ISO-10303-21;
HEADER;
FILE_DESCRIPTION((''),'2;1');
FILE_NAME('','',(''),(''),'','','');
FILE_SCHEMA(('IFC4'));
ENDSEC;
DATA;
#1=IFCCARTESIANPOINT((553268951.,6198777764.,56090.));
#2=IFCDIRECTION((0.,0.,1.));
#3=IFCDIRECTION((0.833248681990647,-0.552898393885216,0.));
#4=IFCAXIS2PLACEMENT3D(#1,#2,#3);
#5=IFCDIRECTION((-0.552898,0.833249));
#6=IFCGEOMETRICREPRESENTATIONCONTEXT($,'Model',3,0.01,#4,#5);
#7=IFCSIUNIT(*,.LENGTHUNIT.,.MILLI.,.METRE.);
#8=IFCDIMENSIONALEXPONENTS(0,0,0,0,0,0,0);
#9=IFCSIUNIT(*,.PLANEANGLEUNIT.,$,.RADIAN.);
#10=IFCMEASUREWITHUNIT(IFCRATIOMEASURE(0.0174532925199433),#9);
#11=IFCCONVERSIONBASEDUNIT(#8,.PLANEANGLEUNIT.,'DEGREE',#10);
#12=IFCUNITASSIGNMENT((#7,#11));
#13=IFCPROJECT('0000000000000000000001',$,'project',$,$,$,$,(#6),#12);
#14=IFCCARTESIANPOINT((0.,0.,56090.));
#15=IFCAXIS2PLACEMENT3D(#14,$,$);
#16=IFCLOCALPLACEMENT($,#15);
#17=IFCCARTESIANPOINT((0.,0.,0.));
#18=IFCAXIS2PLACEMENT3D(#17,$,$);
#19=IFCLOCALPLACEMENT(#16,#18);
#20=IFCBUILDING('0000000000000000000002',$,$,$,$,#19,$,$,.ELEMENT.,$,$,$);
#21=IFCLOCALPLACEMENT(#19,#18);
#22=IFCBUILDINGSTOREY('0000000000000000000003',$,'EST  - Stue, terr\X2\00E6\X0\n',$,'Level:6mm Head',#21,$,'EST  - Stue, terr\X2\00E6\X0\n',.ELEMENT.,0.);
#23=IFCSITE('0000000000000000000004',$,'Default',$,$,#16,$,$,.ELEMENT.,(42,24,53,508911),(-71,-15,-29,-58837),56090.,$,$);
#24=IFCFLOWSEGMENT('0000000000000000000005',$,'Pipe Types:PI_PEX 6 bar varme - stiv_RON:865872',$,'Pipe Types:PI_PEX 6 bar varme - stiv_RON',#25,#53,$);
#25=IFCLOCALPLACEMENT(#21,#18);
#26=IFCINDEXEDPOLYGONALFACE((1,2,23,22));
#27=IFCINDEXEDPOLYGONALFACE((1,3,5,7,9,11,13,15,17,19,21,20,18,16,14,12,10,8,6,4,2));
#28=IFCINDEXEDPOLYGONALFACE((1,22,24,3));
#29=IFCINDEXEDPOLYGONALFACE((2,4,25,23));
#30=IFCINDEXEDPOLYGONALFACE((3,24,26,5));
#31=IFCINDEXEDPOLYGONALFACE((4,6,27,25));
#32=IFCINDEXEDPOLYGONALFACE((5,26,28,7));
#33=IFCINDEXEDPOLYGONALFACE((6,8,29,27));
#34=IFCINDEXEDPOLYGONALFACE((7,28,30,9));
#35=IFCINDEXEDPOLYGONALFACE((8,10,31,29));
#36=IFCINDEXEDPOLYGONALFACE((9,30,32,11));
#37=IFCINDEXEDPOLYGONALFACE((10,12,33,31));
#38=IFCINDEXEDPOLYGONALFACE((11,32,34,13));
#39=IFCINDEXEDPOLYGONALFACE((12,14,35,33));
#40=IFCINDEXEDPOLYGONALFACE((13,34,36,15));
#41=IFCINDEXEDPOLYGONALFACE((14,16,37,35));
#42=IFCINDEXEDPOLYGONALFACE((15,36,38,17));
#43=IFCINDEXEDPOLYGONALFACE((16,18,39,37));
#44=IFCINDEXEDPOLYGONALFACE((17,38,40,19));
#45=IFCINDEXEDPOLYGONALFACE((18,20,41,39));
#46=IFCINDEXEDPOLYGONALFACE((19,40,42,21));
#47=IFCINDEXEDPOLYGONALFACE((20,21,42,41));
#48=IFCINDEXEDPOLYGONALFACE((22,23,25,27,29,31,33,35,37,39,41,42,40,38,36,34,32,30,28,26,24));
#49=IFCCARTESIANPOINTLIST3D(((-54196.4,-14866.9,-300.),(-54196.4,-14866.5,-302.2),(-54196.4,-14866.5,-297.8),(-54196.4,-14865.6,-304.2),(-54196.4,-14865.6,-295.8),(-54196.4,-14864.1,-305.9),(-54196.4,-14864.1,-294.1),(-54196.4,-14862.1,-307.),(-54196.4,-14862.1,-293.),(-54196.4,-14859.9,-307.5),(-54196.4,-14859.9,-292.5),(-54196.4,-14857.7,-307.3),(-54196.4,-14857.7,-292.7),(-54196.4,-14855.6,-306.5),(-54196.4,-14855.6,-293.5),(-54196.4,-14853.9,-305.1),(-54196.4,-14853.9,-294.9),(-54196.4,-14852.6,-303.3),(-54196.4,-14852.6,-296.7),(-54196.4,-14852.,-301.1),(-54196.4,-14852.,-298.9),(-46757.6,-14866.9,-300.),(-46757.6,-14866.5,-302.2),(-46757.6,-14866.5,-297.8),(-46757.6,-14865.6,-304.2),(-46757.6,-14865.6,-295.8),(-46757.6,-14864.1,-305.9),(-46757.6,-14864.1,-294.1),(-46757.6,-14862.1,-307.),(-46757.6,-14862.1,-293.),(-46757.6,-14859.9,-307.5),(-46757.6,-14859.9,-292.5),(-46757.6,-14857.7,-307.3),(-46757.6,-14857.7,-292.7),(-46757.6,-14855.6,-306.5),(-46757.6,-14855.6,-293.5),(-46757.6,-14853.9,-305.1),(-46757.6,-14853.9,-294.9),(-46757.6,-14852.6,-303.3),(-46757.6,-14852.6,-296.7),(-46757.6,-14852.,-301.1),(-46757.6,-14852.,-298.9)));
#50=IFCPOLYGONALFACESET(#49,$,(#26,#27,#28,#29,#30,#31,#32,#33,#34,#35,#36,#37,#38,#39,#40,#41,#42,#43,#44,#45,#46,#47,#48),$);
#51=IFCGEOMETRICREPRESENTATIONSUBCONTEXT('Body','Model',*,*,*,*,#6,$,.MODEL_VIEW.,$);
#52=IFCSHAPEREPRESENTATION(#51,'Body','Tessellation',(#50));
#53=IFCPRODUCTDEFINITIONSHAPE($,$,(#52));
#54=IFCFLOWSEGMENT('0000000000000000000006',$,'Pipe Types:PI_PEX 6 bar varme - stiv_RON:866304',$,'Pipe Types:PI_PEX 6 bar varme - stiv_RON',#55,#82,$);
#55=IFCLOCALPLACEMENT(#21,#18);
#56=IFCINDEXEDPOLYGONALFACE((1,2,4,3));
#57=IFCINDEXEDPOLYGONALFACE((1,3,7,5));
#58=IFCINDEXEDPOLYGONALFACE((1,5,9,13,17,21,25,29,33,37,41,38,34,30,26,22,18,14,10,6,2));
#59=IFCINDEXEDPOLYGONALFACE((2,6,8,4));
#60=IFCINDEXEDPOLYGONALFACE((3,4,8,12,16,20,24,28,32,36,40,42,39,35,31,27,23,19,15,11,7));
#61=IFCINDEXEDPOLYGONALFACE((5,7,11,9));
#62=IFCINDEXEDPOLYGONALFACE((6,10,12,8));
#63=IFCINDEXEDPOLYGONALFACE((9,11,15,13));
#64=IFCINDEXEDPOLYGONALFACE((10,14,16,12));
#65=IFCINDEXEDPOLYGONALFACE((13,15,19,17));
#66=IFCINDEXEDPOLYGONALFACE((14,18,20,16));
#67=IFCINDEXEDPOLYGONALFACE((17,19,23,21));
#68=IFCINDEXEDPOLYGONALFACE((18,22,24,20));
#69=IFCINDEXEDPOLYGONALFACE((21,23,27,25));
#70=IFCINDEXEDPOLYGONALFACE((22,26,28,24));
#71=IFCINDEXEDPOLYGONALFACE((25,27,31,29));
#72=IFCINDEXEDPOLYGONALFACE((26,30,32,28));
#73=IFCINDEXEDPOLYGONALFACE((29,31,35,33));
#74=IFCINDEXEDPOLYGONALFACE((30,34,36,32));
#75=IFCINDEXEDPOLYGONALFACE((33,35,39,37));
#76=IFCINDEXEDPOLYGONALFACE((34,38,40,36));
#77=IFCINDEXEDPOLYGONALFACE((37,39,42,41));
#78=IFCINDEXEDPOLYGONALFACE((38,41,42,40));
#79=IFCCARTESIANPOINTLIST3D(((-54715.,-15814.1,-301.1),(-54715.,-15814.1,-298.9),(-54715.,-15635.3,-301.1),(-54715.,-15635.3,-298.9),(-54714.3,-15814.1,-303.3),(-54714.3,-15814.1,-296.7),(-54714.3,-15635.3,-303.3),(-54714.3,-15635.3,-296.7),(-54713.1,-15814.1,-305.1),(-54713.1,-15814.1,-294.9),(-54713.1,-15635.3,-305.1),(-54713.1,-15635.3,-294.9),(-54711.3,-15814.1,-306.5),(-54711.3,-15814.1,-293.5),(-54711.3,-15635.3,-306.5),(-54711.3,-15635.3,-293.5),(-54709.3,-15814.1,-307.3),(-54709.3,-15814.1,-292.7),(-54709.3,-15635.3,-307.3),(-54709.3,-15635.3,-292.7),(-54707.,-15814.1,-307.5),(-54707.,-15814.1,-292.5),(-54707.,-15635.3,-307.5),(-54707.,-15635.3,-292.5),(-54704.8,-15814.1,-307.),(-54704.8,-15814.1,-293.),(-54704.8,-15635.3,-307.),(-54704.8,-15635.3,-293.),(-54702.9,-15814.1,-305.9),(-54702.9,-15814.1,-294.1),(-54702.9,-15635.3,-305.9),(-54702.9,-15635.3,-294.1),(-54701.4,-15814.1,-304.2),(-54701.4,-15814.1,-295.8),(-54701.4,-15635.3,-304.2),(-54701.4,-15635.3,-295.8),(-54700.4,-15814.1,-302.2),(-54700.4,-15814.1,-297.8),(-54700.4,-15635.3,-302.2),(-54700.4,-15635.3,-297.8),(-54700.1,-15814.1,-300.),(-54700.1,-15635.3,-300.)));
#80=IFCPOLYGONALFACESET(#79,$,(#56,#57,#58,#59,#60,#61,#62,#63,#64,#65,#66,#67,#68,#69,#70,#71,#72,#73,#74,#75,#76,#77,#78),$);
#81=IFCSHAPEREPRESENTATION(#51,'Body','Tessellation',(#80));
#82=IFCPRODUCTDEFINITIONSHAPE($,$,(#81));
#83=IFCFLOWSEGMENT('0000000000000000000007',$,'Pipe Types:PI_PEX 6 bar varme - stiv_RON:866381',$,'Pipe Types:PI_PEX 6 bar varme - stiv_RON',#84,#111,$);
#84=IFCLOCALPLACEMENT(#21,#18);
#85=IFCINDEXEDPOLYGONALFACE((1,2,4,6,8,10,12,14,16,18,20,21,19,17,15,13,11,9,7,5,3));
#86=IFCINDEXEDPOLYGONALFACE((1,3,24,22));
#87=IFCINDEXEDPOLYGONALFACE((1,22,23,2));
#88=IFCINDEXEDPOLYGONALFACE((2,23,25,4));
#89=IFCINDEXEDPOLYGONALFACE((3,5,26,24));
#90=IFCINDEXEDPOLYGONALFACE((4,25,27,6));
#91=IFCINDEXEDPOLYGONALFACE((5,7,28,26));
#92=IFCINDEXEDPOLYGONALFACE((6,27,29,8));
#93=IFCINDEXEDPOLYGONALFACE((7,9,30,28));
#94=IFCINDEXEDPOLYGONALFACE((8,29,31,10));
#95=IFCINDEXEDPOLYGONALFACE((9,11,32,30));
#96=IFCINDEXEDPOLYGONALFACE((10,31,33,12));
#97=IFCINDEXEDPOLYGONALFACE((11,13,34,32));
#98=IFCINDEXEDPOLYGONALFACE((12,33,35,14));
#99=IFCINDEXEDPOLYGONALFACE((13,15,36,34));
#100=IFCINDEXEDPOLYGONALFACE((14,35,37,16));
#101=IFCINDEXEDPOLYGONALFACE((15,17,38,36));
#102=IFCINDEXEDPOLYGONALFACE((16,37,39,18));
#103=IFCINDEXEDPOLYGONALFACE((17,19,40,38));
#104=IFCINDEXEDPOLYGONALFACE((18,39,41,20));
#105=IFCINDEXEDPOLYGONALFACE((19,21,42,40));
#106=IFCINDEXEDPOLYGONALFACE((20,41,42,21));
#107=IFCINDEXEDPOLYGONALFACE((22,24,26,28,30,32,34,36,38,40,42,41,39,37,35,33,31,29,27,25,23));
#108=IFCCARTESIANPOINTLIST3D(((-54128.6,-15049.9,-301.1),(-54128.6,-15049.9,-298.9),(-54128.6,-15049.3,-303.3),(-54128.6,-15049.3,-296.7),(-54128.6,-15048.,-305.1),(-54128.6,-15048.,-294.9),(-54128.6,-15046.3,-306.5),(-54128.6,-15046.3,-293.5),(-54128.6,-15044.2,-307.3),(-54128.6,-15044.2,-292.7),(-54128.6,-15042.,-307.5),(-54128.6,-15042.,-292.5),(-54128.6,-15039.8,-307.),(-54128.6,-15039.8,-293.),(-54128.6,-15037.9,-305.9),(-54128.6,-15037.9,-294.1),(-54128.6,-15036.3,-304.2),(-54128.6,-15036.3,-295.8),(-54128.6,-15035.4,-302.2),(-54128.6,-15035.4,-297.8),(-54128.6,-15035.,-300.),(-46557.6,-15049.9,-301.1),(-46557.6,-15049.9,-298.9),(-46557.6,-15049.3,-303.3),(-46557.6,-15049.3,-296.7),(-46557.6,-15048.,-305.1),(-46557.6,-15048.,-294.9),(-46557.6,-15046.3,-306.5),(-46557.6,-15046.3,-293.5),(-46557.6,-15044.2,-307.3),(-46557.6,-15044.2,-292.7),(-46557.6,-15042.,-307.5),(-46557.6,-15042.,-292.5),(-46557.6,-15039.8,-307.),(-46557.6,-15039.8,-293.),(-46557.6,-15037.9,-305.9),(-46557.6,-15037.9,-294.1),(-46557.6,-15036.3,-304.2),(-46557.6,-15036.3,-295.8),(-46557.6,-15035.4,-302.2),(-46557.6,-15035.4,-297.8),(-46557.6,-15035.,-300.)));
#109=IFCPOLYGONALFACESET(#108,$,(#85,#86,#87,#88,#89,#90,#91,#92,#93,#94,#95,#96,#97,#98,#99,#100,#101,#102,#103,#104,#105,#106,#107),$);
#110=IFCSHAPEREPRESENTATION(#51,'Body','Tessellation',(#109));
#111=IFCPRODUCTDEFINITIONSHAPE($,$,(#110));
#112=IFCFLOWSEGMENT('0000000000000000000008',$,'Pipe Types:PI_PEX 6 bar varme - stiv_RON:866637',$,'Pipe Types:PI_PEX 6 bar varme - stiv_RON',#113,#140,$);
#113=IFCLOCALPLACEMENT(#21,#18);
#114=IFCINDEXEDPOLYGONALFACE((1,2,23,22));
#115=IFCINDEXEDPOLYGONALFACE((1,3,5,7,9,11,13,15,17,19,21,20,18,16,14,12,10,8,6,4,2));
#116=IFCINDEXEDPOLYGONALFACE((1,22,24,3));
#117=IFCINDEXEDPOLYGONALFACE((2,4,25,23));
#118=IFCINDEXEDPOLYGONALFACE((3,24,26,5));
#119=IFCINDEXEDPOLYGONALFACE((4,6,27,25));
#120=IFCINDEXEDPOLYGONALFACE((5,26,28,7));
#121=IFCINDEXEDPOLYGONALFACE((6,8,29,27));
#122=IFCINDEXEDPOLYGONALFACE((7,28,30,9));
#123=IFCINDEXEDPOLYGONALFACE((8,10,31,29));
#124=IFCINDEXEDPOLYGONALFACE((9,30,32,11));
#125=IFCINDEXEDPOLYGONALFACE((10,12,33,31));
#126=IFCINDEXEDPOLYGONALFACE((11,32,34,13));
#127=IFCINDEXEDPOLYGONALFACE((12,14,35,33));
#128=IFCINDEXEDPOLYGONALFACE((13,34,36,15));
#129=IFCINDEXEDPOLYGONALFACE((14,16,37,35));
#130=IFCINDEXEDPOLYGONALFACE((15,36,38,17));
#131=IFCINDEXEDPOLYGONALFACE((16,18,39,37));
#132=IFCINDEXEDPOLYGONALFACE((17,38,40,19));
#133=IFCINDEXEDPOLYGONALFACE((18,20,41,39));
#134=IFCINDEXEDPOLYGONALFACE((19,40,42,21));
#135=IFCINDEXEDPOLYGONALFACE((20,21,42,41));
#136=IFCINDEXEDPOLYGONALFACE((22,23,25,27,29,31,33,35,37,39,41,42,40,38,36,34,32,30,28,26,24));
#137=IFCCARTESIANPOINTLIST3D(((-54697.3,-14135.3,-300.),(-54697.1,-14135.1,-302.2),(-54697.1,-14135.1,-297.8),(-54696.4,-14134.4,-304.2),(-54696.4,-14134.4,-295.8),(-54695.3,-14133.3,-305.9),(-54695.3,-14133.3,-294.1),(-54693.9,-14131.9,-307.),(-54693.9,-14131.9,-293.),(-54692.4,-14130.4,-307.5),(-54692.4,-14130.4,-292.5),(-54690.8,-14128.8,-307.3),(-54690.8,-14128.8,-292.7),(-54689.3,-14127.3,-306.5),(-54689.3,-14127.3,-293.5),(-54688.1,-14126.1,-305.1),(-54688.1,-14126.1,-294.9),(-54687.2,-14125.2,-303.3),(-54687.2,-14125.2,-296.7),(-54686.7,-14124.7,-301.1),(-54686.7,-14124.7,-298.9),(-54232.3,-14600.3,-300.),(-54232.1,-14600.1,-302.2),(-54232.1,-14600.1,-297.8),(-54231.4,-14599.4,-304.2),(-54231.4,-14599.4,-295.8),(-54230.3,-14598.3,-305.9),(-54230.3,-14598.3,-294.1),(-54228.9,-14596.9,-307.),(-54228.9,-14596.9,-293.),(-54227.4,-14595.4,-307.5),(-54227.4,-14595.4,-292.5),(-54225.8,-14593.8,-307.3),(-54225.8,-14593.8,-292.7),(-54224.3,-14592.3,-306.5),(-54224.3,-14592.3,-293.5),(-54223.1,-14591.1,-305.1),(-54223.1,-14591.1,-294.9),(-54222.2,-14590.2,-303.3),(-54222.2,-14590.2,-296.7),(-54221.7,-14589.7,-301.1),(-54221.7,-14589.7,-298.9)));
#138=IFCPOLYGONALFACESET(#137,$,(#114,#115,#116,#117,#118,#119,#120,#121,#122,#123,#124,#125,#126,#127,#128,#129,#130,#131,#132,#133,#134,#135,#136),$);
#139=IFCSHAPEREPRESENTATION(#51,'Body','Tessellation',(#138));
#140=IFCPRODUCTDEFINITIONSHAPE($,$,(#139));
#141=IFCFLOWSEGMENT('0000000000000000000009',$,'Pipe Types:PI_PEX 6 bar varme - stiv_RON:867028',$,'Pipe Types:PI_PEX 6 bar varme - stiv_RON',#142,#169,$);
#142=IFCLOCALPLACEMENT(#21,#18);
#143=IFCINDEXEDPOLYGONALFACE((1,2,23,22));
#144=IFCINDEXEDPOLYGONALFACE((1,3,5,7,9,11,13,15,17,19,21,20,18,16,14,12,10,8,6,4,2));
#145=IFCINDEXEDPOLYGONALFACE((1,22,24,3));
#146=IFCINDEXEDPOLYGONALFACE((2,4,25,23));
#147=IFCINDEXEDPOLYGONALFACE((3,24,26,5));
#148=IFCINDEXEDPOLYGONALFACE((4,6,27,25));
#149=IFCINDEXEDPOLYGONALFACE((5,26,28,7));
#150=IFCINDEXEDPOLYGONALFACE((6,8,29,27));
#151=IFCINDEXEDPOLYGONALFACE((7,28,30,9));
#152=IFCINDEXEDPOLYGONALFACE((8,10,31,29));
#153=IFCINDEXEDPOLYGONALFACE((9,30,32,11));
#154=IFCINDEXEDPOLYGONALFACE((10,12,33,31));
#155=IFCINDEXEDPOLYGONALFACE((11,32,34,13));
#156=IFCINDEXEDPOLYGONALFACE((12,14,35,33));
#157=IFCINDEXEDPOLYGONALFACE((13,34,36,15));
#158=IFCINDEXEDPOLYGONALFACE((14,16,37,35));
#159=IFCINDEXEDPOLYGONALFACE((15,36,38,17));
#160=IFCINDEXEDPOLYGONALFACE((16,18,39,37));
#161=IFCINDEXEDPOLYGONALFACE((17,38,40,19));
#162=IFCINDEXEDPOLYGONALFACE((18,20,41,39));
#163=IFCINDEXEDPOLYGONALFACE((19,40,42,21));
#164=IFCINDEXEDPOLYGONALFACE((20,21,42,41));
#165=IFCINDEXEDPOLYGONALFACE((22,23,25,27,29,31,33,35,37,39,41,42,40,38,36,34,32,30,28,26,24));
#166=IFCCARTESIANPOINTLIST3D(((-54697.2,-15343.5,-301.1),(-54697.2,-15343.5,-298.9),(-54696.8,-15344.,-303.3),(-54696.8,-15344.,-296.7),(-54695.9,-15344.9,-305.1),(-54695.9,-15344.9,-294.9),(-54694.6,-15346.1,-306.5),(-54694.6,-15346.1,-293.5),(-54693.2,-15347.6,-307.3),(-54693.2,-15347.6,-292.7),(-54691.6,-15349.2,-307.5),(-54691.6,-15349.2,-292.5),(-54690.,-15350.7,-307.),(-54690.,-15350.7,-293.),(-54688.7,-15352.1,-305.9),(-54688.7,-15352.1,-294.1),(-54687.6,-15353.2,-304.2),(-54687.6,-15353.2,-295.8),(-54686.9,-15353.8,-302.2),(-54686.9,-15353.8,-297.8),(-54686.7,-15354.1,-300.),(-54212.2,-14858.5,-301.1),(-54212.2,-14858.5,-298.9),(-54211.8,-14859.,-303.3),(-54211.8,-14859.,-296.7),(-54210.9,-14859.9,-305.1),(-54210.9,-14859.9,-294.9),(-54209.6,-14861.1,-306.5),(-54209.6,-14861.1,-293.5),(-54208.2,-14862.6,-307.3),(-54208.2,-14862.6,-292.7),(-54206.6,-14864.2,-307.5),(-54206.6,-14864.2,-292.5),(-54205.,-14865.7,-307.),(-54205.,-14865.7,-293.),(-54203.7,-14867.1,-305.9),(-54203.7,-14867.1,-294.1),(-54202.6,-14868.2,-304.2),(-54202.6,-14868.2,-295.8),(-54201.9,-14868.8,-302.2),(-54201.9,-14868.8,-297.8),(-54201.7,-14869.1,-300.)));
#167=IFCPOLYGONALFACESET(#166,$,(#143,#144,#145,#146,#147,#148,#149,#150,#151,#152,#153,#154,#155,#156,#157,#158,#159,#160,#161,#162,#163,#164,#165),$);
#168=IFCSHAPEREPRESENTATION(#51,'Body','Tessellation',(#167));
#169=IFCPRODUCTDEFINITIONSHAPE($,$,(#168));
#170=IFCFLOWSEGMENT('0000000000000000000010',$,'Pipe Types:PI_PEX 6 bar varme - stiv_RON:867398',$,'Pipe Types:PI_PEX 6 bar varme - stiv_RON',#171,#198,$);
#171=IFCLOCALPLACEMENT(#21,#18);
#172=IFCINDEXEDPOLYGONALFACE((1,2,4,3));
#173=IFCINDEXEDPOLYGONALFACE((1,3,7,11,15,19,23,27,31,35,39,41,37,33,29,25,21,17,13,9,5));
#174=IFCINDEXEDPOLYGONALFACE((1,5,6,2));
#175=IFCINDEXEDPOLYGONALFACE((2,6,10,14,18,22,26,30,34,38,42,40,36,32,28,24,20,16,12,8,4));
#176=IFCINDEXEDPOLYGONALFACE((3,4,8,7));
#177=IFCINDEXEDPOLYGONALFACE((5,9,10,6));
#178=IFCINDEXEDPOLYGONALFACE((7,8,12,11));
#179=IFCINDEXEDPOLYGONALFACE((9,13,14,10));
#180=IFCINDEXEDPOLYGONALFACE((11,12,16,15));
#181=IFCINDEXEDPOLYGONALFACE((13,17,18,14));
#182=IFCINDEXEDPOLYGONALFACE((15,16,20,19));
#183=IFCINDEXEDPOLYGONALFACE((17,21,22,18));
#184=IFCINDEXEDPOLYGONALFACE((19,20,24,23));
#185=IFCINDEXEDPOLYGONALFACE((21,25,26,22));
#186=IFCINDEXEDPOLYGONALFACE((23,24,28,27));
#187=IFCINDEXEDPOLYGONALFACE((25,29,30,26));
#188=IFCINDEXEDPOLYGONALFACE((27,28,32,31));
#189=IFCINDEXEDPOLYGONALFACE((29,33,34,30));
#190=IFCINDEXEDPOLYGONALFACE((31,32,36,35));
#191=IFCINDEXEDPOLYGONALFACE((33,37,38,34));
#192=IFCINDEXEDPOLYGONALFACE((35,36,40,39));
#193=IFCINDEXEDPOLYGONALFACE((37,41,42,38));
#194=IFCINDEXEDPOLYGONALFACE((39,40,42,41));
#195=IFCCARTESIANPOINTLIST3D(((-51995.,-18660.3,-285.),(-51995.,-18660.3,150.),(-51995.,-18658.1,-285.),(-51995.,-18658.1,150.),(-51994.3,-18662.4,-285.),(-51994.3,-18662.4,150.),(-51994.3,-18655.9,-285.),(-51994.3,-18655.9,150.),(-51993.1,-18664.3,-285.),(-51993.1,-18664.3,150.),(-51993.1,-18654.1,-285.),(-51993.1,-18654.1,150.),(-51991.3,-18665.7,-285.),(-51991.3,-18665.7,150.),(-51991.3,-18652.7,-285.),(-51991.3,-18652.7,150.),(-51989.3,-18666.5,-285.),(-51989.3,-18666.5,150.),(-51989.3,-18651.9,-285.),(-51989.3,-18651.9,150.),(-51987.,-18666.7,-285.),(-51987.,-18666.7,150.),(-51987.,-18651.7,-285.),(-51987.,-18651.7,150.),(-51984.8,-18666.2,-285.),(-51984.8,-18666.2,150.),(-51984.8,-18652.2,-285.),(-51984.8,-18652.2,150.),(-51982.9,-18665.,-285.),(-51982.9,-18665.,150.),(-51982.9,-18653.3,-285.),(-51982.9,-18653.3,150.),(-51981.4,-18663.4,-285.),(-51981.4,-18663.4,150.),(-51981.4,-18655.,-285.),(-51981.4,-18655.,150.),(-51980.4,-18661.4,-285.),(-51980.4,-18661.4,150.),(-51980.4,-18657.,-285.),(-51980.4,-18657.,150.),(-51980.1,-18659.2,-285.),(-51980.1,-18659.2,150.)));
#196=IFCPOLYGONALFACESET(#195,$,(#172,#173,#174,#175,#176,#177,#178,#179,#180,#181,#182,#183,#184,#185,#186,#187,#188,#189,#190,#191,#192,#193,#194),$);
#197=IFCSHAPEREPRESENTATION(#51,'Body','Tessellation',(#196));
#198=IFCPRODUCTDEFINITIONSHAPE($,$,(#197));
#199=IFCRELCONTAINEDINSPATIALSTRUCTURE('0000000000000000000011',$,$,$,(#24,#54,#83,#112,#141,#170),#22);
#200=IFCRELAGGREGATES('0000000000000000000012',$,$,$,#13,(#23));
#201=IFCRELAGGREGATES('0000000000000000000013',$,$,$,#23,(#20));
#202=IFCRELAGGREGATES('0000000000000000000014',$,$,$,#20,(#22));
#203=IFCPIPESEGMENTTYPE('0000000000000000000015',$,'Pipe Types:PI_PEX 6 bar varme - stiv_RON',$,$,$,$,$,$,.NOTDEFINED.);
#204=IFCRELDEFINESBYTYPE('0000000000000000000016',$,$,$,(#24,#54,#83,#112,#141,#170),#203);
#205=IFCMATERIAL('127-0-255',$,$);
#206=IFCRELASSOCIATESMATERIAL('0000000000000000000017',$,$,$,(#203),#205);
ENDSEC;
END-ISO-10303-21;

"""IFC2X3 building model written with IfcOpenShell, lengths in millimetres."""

from ifc_helpers import new_model, entity, si_unit, converted_unit, direction, frame, frame_2d, origin, origin_2d_with_axis, place, context, subcontext, project, spatial, circle, extrude, material, type_object, element, save


model = new_model("IFC2X3")

# Units and contexts
model_context = context("Model", 3, precision=0.01, world=frame((553268951.0, 6198777764.0, 56090.0), z_axis=(0.0, 0.0, 1.0), x_axis=(0.833248681990647, -0.552898393885216, 0.0)), true_north=direction((-0.552898, 0.833249)))
body_context = subcontext(model_context, "Body", "Model", "MODEL_VIEW")
ifc_project = project(units=[si_unit("LENGTHUNIT", "METRE", prefix="MILLI"), converted_unit("PLANEANGLEUNIT", "DEGREE", entity("IfcRatioMeasure", 0.0174532925199433), si_unit("PLANEANGLEUNIT", "RADIAN"), dimensions=[0, 0, 0, 0, 0, 0, 0])], contexts=[model_context])

# Site, building, storey
site_placement = place(None, frame((0.0, 0.0, 56090.0)))
site = spatial("IfcSite", under=ifc_project, at=site_placement, Name="Default", CompositionType="ELEMENT", RefLatitude=(42, 24, 53, 508911), RefLongitude=(-71, -15, -29, -58837), RefElevation=56090.0)
building_placement = place(site_placement, origin())
building = spatial("IfcBuilding", under=site, at=building_placement, CompositionType="ELEMENT")
storey_placement = place(building_placement, frame((0.0, 0.0, 0.0)))
storey = spatial("IfcBuildingStorey", under=building, at=storey_placement, Name="EST  - Stue, terræn", ObjectType="Level:6mm Head", LongName="EST  - Stue, terræn", CompositionType="ELEMENT", Elevation=0.0)

# Flow segments
ifc_material = material(Name="127-0-255")
pipe_segment_type = type_object("IfcPipeSegmentType", Name="Pipe Types:PI_PEX 6 bar varme - stiv_RON", PredefinedType="NOTDEFINED", material=ifc_material)
flow_segment_1_placement = place(storey_placement, origin())
element("IfcFlowSegment", 1, at=flow_segment_1_placement, inside=storey, type_object=pipe_segment_type, Name="Pipe Types:PI_PEX 6 bar varme - stiv_RON:865872", ObjectType="Pipe Types:PI_PEX 6 bar varme - stiv_RON", context=body_context, shape_type="SweptSolid", body=[
    extrude(circle(Radius=7.5, at=origin_2d_with_axis()), frame((-54196.4, -14859.4, -300.0), z_axis=(1.0, 0.0, 0.0), x_axis=(0.0, -1.0, 0.0)), (0.0, 0.0, 1.0), 7438.8),
])
flow_segment_2_placement = place(storey_placement, origin())
element("IfcFlowSegment", 2, at=flow_segment_2_placement, inside=storey, type_object=pipe_segment_type, Name="Pipe Types:PI_PEX 6 bar varme - stiv_RON:866304", ObjectType="Pipe Types:PI_PEX 6 bar varme - stiv_RON", context=body_context, shape_type="SweptSolid", body=[
    extrude(circle(Radius=7.5, at=origin_2d_with_axis()), frame((-54707.6, -15814.1, -300.0), z_axis=(0.0, 1.0, 0.0), x_axis=(1.0, 0.0, 0.0)), (0.0, 0.0, 1.0), 178.8),
])
flow_segment_3_placement = place(storey_placement, origin())
element("IfcFlowSegment", 3, at=flow_segment_3_placement, inside=storey, type_object=pipe_segment_type, Name="Pipe Types:PI_PEX 6 bar varme - stiv_RON:866381", ObjectType="Pipe Types:PI_PEX 6 bar varme - stiv_RON", context=body_context, shape_type="SweptSolid", body=[
    extrude(circle(Radius=7.5, at=frame_2d((0.0, 0.0), x_axis=(1.0, 0.0))), frame((-54128.6, -15042.5, -300.0), z_axis=(1.0, 0.0, 0.0), x_axis=(0.0, 1.0, 0.0)), (0.0, 0.0, 1.0), 7571.0),
])
flow_segment_4_placement = place(storey_placement, origin())
element("IfcFlowSegment", 4, at=flow_segment_4_placement, inside=storey, type_object=pipe_segment_type, Name="Pipe Types:PI_PEX 6 bar varme - stiv_RON:866637", ObjectType="Pipe Types:PI_PEX 6 bar varme - stiv_RON", context=body_context, shape_type="SweptSolid", body=[
    extrude(circle(Radius=7.5, at=origin_2d_with_axis()), frame((-54692.0, -14130.0, -300.0), z_axis=(0.707107, -0.707107, 0.0), x_axis=(-0.707107, -0.707107, 0.0)), (0.0, 0.0, 1.0), 657.6),
])
flow_segment_5_placement = place(storey_placement, origin())
element("IfcFlowSegment", 5, at=flow_segment_5_placement, inside=storey, type_object=pipe_segment_type, Name="Pipe Types:PI_PEX 6 bar varme - stiv_RON:867028", ObjectType="Pipe Types:PI_PEX 6 bar varme - stiv_RON", context=body_context, shape_type="SweptSolid", body=[
    extrude(circle(Radius=7.5, at=origin_2d_with_axis()), frame((-54692.0, -15348.8, -300.0), z_axis=(0.707107, 0.707107, 0.0), x_axis=(0.707107, -0.707107, 0.0)), (0.0, 0.0, 1.0), 685.9),
])
flow_segment_6_placement = place(storey_placement, origin())
element("IfcFlowSegment", 6, at=flow_segment_6_placement, inside=storey, type_object=pipe_segment_type, Name="Pipe Types:PI_PEX 6 bar varme - stiv_RON:867398", ObjectType="Pipe Types:PI_PEX 6 bar varme - stiv_RON", context=body_context, shape_type="SweptSolid", body=[
    extrude(circle(Radius=7.5, at=origin_2d_with_axis()), frame((-51987.6, -18659.2, -285.0)), (0.0, 0.0, 1.0), 435.0),
])

save(model, "model.ifc")
